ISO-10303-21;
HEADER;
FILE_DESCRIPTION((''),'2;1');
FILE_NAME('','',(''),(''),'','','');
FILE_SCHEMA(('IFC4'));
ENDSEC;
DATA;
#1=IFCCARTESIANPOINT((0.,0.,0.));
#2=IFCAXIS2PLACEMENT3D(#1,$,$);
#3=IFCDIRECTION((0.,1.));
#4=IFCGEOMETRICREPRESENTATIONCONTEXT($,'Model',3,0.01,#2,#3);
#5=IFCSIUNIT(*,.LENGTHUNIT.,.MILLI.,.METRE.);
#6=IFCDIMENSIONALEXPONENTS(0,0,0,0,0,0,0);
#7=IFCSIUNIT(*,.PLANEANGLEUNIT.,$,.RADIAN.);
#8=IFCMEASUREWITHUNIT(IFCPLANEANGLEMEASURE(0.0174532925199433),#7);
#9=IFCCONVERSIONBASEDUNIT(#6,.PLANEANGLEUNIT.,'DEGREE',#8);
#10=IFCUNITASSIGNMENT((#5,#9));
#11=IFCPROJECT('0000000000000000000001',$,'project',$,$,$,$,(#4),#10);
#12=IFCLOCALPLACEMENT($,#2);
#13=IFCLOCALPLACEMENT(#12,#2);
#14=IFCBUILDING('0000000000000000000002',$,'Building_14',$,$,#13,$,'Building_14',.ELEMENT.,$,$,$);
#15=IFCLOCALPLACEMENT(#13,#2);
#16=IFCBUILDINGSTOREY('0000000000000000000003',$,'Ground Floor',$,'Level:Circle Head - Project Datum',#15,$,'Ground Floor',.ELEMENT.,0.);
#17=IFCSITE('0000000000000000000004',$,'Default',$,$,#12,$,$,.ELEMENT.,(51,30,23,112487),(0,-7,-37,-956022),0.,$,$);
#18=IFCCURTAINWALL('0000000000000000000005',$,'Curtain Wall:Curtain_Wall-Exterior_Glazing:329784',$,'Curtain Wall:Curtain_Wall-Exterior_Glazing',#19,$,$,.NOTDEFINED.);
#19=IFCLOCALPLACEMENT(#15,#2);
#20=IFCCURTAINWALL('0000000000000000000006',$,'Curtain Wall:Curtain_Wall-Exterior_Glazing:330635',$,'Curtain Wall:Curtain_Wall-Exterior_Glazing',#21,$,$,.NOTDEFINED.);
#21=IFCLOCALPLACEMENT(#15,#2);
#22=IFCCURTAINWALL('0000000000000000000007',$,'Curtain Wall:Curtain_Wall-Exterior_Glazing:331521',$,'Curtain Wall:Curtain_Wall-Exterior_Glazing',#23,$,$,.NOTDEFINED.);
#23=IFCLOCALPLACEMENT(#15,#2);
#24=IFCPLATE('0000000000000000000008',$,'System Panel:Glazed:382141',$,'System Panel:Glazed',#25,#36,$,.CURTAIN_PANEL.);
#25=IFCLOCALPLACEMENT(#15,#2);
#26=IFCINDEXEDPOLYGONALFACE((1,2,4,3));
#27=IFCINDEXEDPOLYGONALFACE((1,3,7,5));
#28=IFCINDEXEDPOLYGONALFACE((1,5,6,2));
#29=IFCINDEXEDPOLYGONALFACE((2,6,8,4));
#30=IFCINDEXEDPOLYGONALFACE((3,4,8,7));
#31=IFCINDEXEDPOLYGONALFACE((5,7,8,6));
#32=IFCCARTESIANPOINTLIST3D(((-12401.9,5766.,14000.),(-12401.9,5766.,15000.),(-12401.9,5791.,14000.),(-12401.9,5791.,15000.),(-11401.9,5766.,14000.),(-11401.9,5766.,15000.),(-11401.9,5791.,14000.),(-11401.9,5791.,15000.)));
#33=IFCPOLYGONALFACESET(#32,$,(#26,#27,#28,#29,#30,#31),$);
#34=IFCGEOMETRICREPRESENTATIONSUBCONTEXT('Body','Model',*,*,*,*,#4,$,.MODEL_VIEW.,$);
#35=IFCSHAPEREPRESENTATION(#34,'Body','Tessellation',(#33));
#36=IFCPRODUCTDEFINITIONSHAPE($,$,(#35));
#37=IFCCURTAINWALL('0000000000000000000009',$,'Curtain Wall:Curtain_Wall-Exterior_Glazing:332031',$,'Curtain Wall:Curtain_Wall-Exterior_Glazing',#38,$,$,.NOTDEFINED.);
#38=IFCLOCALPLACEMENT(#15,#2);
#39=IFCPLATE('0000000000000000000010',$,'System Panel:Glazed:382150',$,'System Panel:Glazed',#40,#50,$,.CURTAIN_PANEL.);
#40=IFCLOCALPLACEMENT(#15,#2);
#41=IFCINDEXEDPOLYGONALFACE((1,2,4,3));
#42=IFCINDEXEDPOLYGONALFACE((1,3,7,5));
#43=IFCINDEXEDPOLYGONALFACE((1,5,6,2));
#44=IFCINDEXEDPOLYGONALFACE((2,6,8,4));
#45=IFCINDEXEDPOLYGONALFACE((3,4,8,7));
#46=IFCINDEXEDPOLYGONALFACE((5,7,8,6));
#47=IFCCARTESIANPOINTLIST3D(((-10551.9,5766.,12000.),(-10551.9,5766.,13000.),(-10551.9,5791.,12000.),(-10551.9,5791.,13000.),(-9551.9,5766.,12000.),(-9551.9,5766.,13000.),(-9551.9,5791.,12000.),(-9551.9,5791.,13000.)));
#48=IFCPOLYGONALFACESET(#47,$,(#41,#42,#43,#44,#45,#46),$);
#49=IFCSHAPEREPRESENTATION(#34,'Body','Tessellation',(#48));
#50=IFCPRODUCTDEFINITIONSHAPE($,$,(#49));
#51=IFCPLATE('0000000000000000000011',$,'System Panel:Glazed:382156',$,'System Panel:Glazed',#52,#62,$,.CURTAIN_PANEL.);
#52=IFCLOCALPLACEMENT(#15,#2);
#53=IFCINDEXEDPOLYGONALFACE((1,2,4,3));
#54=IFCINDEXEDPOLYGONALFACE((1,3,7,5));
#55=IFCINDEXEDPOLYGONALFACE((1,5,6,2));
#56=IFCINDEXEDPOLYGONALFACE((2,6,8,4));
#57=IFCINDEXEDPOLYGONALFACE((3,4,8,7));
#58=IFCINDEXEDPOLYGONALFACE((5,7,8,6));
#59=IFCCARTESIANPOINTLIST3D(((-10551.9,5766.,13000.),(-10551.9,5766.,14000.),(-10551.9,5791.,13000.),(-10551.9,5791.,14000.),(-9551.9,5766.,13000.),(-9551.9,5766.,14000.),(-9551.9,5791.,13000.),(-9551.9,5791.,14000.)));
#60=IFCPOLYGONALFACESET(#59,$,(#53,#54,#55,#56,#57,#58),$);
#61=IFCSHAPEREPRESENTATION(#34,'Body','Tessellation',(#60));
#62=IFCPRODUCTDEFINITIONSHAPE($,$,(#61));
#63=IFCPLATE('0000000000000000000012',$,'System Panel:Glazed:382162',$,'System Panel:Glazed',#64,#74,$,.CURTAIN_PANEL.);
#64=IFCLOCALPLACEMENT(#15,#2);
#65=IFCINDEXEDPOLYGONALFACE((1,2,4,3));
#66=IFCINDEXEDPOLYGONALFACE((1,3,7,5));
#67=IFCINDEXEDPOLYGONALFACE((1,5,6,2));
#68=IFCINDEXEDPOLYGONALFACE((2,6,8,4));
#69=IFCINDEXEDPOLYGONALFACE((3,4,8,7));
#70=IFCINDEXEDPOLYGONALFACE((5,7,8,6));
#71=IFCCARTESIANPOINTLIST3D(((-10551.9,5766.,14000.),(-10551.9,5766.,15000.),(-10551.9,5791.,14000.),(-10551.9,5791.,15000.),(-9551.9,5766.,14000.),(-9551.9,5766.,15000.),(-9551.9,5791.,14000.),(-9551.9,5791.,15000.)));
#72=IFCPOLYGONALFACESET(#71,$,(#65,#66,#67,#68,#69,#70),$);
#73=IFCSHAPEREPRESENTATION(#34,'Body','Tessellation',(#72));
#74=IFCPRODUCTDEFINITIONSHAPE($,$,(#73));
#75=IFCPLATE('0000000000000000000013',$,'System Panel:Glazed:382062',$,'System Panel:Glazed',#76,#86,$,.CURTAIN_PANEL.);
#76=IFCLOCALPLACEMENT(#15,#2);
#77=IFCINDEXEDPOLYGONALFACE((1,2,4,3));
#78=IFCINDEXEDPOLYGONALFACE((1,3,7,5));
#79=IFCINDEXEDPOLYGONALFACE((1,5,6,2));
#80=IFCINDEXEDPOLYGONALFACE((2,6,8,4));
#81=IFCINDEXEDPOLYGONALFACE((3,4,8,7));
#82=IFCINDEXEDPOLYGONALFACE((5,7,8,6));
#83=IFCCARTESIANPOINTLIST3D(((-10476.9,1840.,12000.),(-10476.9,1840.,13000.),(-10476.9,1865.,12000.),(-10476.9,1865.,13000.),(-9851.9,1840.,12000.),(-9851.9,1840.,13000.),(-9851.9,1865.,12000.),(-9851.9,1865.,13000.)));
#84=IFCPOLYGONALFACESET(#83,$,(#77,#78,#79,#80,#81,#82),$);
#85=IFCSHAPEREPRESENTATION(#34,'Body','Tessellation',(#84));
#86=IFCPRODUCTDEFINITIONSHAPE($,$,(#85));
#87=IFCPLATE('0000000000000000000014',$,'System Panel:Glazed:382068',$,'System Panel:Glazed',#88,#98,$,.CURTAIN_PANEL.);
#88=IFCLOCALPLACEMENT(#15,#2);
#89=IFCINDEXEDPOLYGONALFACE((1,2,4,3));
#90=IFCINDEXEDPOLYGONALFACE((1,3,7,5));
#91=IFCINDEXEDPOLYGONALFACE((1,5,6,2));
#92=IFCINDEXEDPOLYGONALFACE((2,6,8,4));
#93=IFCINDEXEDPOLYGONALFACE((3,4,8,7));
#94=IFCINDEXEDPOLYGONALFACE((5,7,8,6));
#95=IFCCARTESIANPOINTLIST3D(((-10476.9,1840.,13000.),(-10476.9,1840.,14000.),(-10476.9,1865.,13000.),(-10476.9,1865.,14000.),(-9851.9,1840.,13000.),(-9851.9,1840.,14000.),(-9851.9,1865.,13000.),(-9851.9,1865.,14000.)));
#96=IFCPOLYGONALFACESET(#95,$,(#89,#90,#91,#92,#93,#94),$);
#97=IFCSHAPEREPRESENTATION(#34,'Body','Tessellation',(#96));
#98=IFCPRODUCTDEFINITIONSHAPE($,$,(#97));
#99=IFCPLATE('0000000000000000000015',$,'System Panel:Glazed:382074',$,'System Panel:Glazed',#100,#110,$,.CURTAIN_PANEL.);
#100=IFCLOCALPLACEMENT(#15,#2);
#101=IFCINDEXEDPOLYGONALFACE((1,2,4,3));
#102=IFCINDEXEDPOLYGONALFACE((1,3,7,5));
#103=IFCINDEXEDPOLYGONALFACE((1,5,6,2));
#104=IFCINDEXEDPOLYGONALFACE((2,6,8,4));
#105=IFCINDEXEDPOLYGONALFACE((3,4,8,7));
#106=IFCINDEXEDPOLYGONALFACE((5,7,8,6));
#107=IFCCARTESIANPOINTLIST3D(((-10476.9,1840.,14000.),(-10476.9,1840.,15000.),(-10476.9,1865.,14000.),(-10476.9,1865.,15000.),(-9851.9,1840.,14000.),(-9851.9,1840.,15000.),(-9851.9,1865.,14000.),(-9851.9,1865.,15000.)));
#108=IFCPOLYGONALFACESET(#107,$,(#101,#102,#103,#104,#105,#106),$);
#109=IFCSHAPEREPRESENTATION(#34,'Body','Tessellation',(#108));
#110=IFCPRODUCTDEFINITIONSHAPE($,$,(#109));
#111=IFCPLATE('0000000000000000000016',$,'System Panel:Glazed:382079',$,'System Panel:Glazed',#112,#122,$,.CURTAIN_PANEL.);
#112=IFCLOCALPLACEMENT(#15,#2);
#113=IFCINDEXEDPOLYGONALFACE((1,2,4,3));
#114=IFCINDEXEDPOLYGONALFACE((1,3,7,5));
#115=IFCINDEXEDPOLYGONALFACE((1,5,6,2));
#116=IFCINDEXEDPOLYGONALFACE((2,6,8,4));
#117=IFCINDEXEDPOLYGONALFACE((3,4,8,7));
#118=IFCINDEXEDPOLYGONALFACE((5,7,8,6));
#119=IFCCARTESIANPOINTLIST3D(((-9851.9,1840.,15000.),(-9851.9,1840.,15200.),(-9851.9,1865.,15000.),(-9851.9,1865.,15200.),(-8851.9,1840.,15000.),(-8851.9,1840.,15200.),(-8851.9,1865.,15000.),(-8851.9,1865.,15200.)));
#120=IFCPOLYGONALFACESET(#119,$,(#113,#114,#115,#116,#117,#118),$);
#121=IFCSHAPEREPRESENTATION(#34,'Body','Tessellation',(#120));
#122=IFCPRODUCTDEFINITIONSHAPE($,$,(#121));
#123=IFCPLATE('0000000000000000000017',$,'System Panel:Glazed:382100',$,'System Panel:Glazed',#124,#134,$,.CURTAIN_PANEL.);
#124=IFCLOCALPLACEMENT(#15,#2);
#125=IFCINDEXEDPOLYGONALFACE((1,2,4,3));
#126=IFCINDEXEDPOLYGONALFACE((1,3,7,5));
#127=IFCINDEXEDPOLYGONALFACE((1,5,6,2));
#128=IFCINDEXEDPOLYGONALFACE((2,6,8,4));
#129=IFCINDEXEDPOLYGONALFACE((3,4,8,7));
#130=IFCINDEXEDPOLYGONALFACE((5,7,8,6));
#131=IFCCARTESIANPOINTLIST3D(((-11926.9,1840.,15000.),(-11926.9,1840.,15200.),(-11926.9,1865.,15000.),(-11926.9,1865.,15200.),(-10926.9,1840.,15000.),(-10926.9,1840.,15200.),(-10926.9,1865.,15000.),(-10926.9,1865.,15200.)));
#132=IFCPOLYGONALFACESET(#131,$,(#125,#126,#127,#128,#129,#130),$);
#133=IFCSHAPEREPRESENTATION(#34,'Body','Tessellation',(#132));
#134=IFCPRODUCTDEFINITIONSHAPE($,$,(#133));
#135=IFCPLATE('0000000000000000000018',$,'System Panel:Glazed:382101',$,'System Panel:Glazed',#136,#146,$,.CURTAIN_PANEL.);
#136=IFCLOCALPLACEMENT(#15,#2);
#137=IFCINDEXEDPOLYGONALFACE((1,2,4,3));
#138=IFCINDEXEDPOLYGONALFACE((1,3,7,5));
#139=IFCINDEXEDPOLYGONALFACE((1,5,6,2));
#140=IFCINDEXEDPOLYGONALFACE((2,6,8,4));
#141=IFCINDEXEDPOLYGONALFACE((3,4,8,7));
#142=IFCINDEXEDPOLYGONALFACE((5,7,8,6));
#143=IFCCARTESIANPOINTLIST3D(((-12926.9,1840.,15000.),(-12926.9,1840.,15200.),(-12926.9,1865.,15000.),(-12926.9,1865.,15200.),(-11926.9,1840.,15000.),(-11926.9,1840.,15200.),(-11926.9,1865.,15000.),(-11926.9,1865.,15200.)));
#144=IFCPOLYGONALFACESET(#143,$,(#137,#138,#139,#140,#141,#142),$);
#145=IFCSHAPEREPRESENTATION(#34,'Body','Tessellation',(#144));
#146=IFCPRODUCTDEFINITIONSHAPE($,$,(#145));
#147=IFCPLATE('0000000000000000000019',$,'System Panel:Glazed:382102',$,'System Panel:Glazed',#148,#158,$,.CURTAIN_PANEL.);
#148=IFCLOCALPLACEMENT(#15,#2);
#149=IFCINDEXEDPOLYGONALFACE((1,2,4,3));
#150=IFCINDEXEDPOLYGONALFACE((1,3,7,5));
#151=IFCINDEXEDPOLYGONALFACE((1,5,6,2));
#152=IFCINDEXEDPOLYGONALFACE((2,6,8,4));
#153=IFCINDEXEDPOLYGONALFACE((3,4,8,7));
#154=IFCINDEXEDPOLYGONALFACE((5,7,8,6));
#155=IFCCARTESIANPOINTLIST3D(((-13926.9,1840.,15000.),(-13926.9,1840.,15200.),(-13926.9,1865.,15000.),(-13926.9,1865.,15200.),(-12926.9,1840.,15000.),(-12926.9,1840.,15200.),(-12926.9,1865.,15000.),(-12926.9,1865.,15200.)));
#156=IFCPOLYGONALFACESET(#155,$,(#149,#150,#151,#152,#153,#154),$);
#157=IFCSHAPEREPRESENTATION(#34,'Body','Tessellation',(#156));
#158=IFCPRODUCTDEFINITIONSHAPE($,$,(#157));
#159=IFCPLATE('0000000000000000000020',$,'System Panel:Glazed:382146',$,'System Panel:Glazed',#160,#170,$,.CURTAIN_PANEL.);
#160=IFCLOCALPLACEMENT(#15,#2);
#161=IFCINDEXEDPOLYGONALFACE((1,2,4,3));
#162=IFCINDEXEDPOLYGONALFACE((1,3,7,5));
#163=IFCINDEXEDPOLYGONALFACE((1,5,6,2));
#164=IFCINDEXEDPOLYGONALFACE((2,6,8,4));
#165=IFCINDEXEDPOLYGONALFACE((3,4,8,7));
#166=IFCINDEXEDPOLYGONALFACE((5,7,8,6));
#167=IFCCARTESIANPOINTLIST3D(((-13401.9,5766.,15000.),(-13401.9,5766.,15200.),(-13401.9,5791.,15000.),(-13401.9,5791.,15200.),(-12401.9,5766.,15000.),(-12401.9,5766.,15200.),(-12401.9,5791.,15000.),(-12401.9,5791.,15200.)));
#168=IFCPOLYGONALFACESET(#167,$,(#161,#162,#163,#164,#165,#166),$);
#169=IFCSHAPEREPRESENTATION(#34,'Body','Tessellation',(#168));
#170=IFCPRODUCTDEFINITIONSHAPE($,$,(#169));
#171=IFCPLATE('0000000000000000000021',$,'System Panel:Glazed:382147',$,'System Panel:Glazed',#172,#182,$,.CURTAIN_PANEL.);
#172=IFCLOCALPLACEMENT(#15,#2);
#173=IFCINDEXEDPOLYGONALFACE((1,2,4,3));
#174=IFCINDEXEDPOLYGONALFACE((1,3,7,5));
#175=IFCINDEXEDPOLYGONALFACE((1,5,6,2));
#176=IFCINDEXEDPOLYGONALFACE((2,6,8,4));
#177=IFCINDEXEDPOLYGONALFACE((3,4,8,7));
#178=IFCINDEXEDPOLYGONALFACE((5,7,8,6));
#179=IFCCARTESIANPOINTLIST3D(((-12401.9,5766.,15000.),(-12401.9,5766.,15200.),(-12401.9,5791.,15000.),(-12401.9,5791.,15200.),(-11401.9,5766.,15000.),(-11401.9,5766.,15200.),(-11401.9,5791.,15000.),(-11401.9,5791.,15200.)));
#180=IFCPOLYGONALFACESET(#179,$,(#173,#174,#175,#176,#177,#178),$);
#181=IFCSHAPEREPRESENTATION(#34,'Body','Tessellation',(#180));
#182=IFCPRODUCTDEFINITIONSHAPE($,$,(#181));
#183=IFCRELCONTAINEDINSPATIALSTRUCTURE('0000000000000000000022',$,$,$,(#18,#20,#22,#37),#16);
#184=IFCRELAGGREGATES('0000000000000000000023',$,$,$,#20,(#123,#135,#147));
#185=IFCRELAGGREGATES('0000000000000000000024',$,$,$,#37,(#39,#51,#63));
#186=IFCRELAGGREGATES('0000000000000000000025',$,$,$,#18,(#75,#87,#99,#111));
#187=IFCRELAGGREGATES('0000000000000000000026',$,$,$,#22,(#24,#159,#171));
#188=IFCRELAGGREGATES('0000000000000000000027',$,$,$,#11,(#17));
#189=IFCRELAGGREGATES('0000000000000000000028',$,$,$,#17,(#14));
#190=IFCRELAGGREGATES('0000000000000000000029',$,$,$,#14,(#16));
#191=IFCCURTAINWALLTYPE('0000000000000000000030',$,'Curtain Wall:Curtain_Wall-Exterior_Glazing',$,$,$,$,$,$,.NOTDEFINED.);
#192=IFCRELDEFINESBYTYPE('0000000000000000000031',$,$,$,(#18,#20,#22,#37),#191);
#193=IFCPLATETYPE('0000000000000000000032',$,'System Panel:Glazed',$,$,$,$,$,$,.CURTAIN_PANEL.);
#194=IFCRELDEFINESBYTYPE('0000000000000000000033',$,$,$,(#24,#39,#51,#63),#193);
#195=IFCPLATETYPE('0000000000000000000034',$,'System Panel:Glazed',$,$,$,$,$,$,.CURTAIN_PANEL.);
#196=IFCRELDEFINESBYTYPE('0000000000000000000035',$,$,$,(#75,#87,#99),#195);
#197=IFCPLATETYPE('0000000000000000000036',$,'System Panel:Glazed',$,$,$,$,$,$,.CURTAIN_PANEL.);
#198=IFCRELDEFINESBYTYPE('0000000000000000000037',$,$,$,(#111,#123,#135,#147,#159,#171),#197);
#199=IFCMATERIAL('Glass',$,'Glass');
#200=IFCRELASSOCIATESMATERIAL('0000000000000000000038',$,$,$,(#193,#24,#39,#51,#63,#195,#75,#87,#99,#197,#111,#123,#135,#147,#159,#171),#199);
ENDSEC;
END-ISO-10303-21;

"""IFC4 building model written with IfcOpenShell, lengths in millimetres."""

from ifc_helpers import new_model, entity, si_unit, converted_unit, direction, frame, origin, place, context, subcontext, project, spatial, indexed_curve, outline, extrude, source, transform, mapped, material, type_object, type_shapes, element, aggregate, save


model = new_model("IFC4")

# Units and contexts
model_context = context("Model", 3, precision=0.01, world=origin(), true_north=direction((0.0, 1.0)))
body_context = subcontext(model_context, "Body", "Model", "MODEL_VIEW")
ifc_project = project(units=[si_unit("LENGTHUNIT", "METRE", prefix="MILLI"), converted_unit("PLANEANGLEUNIT", "DEGREE", entity("IfcPlaneAngleMeasure", 0.0174532925199433), si_unit("PLANEANGLEUNIT", "RADIAN"), dimensions=[0, 0, 0, 0, 0, 0, 0])], contexts=[model_context])

# Site, building, storey
site_placement = place(None, origin())
site = spatial("IfcSite", under=ifc_project, at=site_placement, Name="Default", CompositionType="ELEMENT", RefLatitude=(51, 30, 23, 112487), RefLongitude=(0, -7, -37, -956022), RefElevation=0.0)
building_placement = place(site_placement, origin())
building = spatial("IfcBuilding", under=site, at=building_placement, Name="Building_14", LongName="Building_14", CompositionType="ELEMENT")
storey_placement = place(building_placement, origin())
storey = spatial("IfcBuildingStorey", under=building, at=storey_placement, Name="Ground Floor", ObjectType="Level:Circle Head - Project Datum", LongName="Ground Floor", CompositionType="ELEMENT", Elevation=0.0)

# Curtain walls, plates
curtain_wall_type = type_object("IfcCurtainWallType", Name="Curtain Wall:Curtain_Wall-Exterior_Glazing", PredefinedType="NOTDEFINED")
curtain_wall_1_placement = place(storey_placement, origin())
curtain_wall_1 = element("IfcCurtainWall", 1, at=curtain_wall_1_placement, inside=storey, type_object=curtain_wall_type, Name="Curtain Wall:Curtain_Wall-Exterior_Glazing:329784", ObjectType="Curtain Wall:Curtain_Wall-Exterior_Glazing", PredefinedType="NOTDEFINED")
ifc_material = material(Name="Glass", Category="Glass")
plate_type_1 = type_object("IfcPlateType", Name="System Panel:Glazed", PredefinedType="CURTAIN_PANEL", material=ifc_material)
shared_shape_1 = source(origin(), body_context, "Body", "SweptSolid", [
    extrude(outline(indexed_curve([(-12.5, -500.0), (12.5, -500.0), (12.5, 500.0), (-12.5, 500.0), (-12.5, -500.0)], self_intersect=False)), frame((0.0, -37.0, 0.0), z_axis=(0.0, 0.0, 1.0), x_axis=(0.0, 1.0, 0.0)), (0.0, 0.0, 1.0), 1000.0),
])
type_shapes(plate_type_1, [shared_shape_1])
curtain_wall_2_placement = place(storey_placement, origin())
curtain_wall_2 = element("IfcCurtainWall", 2, at=curtain_wall_2_placement, inside=storey, type_object=curtain_wall_type, Name="Curtain Wall:Curtain_Wall-Exterior_Glazing:330635", ObjectType="Curtain Wall:Curtain_Wall-Exterior_Glazing", PredefinedType="NOTDEFINED")
curtain_wall_3_placement = place(storey_placement, origin())
curtain_wall_3 = element("IfcCurtainWall", 3, at=curtain_wall_3_placement, inside=storey, type_object=curtain_wall_type, Name="Curtain Wall:Curtain_Wall-Exterior_Glazing:331521", ObjectType="Curtain Wall:Curtain_Wall-Exterior_Glazing", PredefinedType="NOTDEFINED")
plate_1_placement = place(curtain_wall_3_placement, frame((-11901.9, 5815.5, 14000.0)))
plate_1 = element("IfcPlate", 4, at=plate_1_placement, type_object=plate_type_1, material=ifc_material, Name="System Panel:Glazed:382141", ObjectType="System Panel:Glazed", PredefinedType="CURTAIN_PANEL", context=body_context, shape_type="MappedRepresentation", body=[
    mapped(shared_shape_1, transform((0.0, 0.0, 0.0), scale=1.0)),
])
curtain_wall_4_placement = place(storey_placement, origin())
curtain_wall_4 = element("IfcCurtainWall", 5, at=curtain_wall_4_placement, inside=storey, type_object=curtain_wall_type, Name="Curtain Wall:Curtain_Wall-Exterior_Glazing:332031", ObjectType="Curtain Wall:Curtain_Wall-Exterior_Glazing", PredefinedType="NOTDEFINED")
plate_2_placement = place(curtain_wall_4_placement, frame((-10051.9, 5815.5, 12000.0)))
plate_2 = element("IfcPlate", 6, at=plate_2_placement, type_object=plate_type_1, material=ifc_material, Name="System Panel:Glazed:382150", ObjectType="System Panel:Glazed", PredefinedType="CURTAIN_PANEL", context=body_context, shape_type="MappedRepresentation", body=[
    mapped(shared_shape_1, transform((0.0, 0.0, 0.0), scale=1.0)),
])
plate_3_placement = place(curtain_wall_4_placement, frame((-10051.9, 5815.5, 13000.0)))
plate_3 = element("IfcPlate", 7, at=plate_3_placement, type_object=plate_type_1, material=ifc_material, Name="System Panel:Glazed:382156", ObjectType="System Panel:Glazed", PredefinedType="CURTAIN_PANEL", context=body_context, shape_type="MappedRepresentation", body=[
    mapped(shared_shape_1, transform((0.0, 0.0, 0.0), scale=1.0)),
])
plate_4_placement = place(curtain_wall_4_placement, frame((-10051.9, 5815.5, 14000.0)))
plate_4 = element("IfcPlate", 8, at=plate_4_placement, type_object=plate_type_1, material=ifc_material, Name="System Panel:Glazed:382162", ObjectType="System Panel:Glazed", PredefinedType="CURTAIN_PANEL", context=body_context, shape_type="MappedRepresentation", body=[
    mapped(shared_shape_1, transform((0.0, 0.0, 0.0), scale=1.0)),
])

# Plates
plate_type_2 = type_object("IfcPlateType", Name="System Panel:Glazed", PredefinedType="CURTAIN_PANEL", material=ifc_material)
shared_shape_2 = source(origin(), body_context, "Body", "SweptSolid", [
    extrude(outline(indexed_curve([(-12.5, -312.5), (12.5, -312.5), (12.5, 312.5), (-12.5, 312.5), (-12.5, -312.5)], self_intersect=False)), frame((0.0, -37.0, 0.0), z_axis=(0.0, 0.0, 1.0), x_axis=(0.0, 1.0, 0.0)), (0.0, 0.0, 1.0), 1000.0),
])
type_shapes(plate_type_2, [shared_shape_2])
plate_5_placement = place(curtain_wall_1_placement, frame((-10164.4, 1815.5, 12000.0), z_axis=(0.0, 0.0, 1.0), x_axis=(-1.0, 0.0, 0.0)))
plate_5 = element("IfcPlate", 9, at=plate_5_placement, type_object=plate_type_2, material=ifc_material, Name="System Panel:Glazed:382062", ObjectType="System Panel:Glazed", PredefinedType="CURTAIN_PANEL", context=body_context, shape_type="MappedRepresentation", body=[
    mapped(shared_shape_2, transform((0.0, 0.0, 0.0), scale=1.0)),
])
plate_6_placement = place(curtain_wall_1_placement, frame((-10164.4, 1815.5, 13000.0), z_axis=(0.0, 0.0, 1.0), x_axis=(-1.0, 0.0, 0.0)))
plate_6 = element("IfcPlate", 10, at=plate_6_placement, type_object=plate_type_2, material=ifc_material, Name="System Panel:Glazed:382068", ObjectType="System Panel:Glazed", PredefinedType="CURTAIN_PANEL", context=body_context, shape_type="MappedRepresentation", body=[
    mapped(shared_shape_2, transform((0.0, 0.0, 0.0), scale=1.0)),
])
plate_7_placement = place(curtain_wall_1_placement, frame((-10164.4, 1815.5, 14000.0), z_axis=(0.0, 0.0, 1.0), x_axis=(-1.0, 0.0, 0.0)))
plate_7 = element("IfcPlate", 11, at=plate_7_placement, type_object=plate_type_2, material=ifc_material, Name="System Panel:Glazed:382074", ObjectType="System Panel:Glazed", PredefinedType="CURTAIN_PANEL", context=body_context, shape_type="MappedRepresentation", body=[
    mapped(shared_shape_2, transform((0.0, 0.0, 0.0), scale=1.0)),
])
plate_type_3 = type_object("IfcPlateType", Name="System Panel:Glazed", PredefinedType="CURTAIN_PANEL", material=ifc_material)
shared_shape_3 = source(origin(), body_context, "Body", "SweptSolid", [
    extrude(outline(indexed_curve([(-12.5, -500.0), (12.5, -500.0), (12.5, 500.0), (-12.5, 500.0), (-12.5, -500.0)], self_intersect=False)), frame((0.0, -37.0, 0.0), z_axis=(0.0, 0.0, 1.0), x_axis=(0.0, 1.0, 0.0)), (0.0, 0.0, 1.0), 200.0),
])
type_shapes(plate_type_3, [shared_shape_3])
plate_8_placement = place(curtain_wall_1_placement, frame((-9351.9, 1815.5, 15000.0), z_axis=(0.0, 0.0, 1.0), x_axis=(-1.0, 0.0, 0.0)))
plate_8 = element("IfcPlate", 12, at=plate_8_placement, type_object=plate_type_3, material=ifc_material, Name="System Panel:Glazed:382079", ObjectType="System Panel:Glazed", PredefinedType="CURTAIN_PANEL", context=body_context, shape_type="MappedRepresentation", body=[
    mapped(shared_shape_3, transform((0.0, 0.0, 0.0), scale=1.0)),
])
plate_9_placement = place(curtain_wall_2_placement, frame((-11426.9, 1815.5, 15000.0), z_axis=(0.0, 0.0, 1.0), x_axis=(-1.0, 0.0, 0.0)))
plate_9 = element("IfcPlate", 13, at=plate_9_placement, type_object=plate_type_3, material=ifc_material, Name="System Panel:Glazed:382100", ObjectType="System Panel:Glazed", PredefinedType="CURTAIN_PANEL", context=body_context, shape_type="MappedRepresentation", body=[
    mapped(shared_shape_3, transform((0.0, 0.0, 0.0), scale=1.0)),
])
plate_10_placement = place(curtain_wall_2_placement, frame((-12426.9, 1815.5, 15000.0), z_axis=(0.0, 0.0, 1.0), x_axis=(-1.0, 0.0, 0.0)))
plate_10 = element("IfcPlate", 14, at=plate_10_placement, type_object=plate_type_3, material=ifc_material, Name="System Panel:Glazed:382101", ObjectType="System Panel:Glazed", PredefinedType="CURTAIN_PANEL", context=body_context, shape_type="MappedRepresentation", body=[
    mapped(shared_shape_3, transform((0.0, 0.0, 0.0), scale=1.0)),
])
plate_11_placement = place(curtain_wall_2_placement, frame((-13426.9, 1815.5, 15000.0), z_axis=(0.0, 0.0, 1.0), x_axis=(-1.0, 0.0, 0.0)))
plate_11 = element("IfcPlate", 15, at=plate_11_placement, type_object=plate_type_3, material=ifc_material, Name="System Panel:Glazed:382102", ObjectType="System Panel:Glazed", PredefinedType="CURTAIN_PANEL", context=body_context, shape_type="MappedRepresentation", body=[
    mapped(shared_shape_3, transform((0.0, 0.0, 0.0), scale=1.0)),
])
aggregate(curtain_wall_2, [plate_9, plate_10, plate_11])
plate_12_placement = place(curtain_wall_3_placement, frame((-12901.9, 5815.5, 15000.0)))
plate_12 = element("IfcPlate", 16, at=plate_12_placement, type_object=plate_type_3, material=ifc_material, Name="System Panel:Glazed:382146", ObjectType="System Panel:Glazed", PredefinedType="CURTAIN_PANEL", context=body_context, shape_type="MappedRepresentation", body=[
    mapped(shared_shape_3, transform((0.0, 0.0, 0.0), scale=1.0)),
])
plate_13_placement = place(curtain_wall_3_placement, frame((-11901.9, 5815.5, 15000.0)))
plate_13 = element("IfcPlate", 17, at=plate_13_placement, type_object=plate_type_3, material=ifc_material, Name="System Panel:Glazed:382147", ObjectType="System Panel:Glazed", PredefinedType="CURTAIN_PANEL", context=body_context, shape_type="MappedRepresentation", body=[
    mapped(shared_shape_3, transform((0.0, 0.0, 0.0), scale=1.0)),
])
aggregate(curtain_wall_4, [plate_2, plate_3, plate_4])
aggregate(curtain_wall_1, [plate_5, plate_6, plate_7, plate_8])
aggregate(curtain_wall_3, [plate_1, plate_12, plate_13])

save(model, "model.ifc")
